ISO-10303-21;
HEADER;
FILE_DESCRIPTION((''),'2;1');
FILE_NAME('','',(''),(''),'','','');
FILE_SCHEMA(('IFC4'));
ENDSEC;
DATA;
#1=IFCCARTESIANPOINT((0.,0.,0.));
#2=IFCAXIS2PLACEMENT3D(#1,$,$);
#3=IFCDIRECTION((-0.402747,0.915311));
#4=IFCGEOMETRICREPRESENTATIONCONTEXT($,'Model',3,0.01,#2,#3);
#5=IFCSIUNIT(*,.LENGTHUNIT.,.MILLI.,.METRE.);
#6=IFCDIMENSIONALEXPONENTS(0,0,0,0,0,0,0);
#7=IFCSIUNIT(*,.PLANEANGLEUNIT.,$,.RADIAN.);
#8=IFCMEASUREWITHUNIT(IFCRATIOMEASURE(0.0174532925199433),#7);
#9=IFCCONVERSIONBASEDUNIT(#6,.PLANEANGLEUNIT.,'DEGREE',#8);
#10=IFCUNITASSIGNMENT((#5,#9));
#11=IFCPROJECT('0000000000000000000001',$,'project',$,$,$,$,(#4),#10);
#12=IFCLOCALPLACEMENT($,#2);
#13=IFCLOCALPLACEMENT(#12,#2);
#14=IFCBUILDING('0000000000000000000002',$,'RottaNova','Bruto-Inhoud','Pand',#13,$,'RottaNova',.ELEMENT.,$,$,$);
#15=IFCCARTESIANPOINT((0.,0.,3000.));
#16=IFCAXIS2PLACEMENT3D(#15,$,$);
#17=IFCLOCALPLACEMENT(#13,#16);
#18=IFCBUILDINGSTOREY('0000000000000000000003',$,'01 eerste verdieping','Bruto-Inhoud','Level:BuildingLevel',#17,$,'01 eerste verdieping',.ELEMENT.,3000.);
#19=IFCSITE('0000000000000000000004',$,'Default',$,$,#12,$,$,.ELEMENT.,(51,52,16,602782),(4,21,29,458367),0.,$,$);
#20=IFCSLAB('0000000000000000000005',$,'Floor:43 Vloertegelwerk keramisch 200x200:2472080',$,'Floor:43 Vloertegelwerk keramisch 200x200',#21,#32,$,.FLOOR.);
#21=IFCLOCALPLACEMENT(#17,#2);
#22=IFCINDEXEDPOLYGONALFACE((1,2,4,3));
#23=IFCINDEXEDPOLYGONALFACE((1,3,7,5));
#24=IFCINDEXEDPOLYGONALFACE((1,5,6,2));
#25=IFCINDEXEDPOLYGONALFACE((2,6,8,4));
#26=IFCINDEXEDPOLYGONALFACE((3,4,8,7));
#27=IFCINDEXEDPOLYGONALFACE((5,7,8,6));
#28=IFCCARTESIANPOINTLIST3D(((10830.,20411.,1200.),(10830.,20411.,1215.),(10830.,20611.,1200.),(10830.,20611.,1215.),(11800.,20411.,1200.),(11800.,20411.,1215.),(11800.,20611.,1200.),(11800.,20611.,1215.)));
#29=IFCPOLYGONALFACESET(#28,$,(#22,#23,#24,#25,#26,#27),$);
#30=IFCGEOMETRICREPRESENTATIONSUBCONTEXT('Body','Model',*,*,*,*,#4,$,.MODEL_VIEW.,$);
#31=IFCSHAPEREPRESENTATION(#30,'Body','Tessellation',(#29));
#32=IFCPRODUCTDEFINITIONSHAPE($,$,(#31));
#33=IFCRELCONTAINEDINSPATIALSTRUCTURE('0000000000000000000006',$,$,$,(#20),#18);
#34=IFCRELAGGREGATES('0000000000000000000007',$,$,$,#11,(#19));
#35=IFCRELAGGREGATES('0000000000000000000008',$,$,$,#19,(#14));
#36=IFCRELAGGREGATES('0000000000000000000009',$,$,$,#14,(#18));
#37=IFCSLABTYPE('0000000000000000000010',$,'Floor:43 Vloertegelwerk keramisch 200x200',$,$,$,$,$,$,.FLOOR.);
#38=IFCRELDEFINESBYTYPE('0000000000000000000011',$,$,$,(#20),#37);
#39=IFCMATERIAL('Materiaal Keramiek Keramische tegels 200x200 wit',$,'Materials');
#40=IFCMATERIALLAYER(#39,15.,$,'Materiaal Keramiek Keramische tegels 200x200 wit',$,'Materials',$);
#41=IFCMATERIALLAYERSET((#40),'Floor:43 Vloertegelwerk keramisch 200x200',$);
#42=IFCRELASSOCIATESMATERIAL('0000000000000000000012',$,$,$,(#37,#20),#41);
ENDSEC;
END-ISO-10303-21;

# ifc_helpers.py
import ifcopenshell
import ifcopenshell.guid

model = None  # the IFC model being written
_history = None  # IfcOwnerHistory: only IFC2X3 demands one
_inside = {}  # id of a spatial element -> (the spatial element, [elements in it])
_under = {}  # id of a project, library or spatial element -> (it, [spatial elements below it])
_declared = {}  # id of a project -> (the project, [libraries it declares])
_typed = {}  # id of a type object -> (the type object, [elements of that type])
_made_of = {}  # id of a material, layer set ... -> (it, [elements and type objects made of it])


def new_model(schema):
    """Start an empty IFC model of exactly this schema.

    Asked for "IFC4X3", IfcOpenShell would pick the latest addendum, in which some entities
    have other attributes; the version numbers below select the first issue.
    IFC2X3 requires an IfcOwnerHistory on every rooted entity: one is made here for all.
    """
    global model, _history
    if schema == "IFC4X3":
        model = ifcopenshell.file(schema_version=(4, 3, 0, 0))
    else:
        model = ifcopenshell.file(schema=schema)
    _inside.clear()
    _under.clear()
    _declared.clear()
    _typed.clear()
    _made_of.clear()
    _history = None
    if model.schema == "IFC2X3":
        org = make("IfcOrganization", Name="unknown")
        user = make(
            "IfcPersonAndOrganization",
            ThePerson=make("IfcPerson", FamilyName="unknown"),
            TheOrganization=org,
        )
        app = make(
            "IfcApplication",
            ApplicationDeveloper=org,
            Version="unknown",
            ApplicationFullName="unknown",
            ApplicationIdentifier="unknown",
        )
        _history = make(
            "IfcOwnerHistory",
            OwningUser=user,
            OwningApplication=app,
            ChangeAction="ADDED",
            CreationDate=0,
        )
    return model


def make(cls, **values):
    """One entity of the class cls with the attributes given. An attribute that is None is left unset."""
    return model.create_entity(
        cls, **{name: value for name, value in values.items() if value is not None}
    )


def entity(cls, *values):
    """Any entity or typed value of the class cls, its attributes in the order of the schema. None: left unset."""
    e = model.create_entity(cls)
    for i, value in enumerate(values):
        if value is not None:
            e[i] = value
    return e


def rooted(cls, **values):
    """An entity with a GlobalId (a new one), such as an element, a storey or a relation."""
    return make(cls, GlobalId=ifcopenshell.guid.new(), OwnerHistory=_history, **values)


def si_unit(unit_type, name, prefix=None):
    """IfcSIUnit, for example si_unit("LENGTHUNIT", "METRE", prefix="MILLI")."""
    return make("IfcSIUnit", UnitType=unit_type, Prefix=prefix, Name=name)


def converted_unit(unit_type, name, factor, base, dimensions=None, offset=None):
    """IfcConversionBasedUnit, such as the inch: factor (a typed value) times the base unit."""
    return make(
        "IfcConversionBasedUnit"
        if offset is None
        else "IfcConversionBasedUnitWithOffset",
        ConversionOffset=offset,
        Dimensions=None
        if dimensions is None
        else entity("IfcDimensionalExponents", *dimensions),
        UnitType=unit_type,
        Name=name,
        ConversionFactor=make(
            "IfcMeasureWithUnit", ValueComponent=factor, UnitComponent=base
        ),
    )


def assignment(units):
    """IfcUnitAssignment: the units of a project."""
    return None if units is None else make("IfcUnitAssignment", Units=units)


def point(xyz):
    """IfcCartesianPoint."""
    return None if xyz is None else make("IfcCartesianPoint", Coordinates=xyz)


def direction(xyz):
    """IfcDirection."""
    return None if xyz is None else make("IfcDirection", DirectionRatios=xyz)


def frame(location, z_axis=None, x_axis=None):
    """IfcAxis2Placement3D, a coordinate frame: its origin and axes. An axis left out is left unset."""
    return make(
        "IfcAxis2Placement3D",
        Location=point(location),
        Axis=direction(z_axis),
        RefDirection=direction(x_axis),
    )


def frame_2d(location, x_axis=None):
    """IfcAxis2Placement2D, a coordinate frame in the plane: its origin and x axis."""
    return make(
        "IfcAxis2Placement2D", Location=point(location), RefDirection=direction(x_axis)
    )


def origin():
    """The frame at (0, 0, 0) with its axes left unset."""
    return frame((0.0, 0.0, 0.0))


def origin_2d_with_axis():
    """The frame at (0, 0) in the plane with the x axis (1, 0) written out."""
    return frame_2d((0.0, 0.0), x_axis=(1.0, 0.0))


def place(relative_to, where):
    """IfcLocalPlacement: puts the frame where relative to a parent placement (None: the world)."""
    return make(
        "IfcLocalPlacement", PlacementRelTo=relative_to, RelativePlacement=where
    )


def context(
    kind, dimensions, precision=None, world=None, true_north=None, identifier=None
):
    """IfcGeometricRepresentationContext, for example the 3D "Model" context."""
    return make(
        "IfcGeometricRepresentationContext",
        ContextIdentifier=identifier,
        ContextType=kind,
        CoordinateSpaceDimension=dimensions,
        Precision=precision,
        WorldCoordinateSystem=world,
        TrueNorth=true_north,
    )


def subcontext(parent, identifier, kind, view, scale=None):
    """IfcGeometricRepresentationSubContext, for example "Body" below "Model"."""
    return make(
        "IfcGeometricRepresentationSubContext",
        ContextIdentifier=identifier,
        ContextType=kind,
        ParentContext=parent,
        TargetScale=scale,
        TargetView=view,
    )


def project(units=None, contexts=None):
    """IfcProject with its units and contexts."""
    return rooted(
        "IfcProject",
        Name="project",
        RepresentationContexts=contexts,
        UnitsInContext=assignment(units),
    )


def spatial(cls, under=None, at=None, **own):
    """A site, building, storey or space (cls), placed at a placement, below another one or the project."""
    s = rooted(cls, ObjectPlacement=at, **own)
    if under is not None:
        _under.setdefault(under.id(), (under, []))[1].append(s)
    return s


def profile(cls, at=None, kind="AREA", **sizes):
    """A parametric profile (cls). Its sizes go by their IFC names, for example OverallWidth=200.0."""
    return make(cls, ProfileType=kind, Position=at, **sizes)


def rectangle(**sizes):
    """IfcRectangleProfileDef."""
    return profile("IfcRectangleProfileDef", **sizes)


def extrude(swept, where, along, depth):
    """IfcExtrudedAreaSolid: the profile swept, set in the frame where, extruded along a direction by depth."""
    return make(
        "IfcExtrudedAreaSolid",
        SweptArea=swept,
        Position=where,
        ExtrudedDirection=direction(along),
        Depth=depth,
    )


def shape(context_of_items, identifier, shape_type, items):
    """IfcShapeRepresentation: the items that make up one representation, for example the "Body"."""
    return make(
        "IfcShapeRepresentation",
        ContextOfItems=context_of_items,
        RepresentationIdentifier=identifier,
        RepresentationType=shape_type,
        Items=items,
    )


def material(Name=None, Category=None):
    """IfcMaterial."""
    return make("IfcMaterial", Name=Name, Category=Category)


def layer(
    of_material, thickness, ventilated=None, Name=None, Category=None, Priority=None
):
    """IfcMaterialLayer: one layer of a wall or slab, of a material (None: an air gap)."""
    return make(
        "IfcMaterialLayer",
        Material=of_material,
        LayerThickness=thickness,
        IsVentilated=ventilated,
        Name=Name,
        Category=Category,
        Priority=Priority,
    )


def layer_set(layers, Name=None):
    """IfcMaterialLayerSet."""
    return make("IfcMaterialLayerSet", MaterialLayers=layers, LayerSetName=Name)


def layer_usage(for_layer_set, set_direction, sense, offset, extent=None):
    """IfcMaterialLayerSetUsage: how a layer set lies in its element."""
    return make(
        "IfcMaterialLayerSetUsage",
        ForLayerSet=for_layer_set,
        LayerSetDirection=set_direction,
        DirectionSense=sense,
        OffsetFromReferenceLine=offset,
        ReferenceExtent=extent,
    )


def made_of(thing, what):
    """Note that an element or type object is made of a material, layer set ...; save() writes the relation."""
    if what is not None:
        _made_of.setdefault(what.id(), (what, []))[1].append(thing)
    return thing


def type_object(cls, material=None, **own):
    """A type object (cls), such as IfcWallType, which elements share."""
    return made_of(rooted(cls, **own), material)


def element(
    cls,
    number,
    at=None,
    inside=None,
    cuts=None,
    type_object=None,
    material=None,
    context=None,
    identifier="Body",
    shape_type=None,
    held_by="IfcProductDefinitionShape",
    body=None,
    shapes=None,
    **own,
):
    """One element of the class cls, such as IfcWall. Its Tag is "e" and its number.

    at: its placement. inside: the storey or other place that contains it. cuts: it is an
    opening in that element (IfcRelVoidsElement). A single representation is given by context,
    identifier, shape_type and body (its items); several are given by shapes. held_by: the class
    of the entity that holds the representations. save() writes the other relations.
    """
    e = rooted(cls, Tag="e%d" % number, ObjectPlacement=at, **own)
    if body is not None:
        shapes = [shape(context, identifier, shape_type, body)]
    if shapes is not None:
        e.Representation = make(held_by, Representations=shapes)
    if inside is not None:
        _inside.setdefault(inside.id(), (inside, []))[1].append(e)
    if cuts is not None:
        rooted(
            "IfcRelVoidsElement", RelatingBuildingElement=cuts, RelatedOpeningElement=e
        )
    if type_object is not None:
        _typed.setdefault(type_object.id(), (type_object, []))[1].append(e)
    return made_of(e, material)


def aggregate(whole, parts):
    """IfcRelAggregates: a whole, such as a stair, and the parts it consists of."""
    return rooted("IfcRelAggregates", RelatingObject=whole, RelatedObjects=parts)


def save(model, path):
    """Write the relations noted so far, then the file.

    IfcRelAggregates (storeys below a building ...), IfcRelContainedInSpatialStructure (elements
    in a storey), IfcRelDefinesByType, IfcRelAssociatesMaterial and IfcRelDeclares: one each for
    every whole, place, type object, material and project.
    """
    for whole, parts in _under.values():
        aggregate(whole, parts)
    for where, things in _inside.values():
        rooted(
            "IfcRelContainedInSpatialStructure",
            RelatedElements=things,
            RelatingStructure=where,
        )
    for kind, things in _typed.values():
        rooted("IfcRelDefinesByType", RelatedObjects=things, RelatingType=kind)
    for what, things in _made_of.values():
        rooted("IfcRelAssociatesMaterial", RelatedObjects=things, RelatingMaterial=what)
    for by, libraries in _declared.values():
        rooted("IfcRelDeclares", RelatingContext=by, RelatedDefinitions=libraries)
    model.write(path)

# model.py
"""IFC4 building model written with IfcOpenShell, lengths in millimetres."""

from ifc_helpers import new_model, entity, si_unit, converted_unit, direction, frame, origin, origin_2d_with_axis, place, context, subcontext, project, spatial, rectangle, extrude, material, layer, layer_set, layer_usage, type_object, element, save


model = new_model("IFC4")

# Units and contexts
model_context = context("Model", 3, precision=0.01, world=origin(), true_north=direction((-0.402747, 0.915311)))
body_context = subcontext(model_context, "Body", "Model", "MODEL_VIEW")
ifc_project = project(units=[si_unit("LENGTHUNIT", "METRE", prefix="MILLI"), converted_unit("PLANEANGLEUNIT", "DEGREE", entity("IfcRatioMeasure", 0.0174532925199433), si_unit("PLANEANGLEUNIT", "RADIAN"), dimensions=[0, 0, 0, 0, 0, 0, 0])], contexts=[model_context])

# Site, building, storey
site_placement = place(None, origin())
site = spatial("IfcSite", under=ifc_project, at=site_placement, Name="Default", CompositionType="ELEMENT", RefLatitude=(51, 52, 16, 602782), RefLongitude=(4, 21, 29, 458367), RefElevation=0.0)
building_placement = place(site_placement, origin())
building = spatial("IfcBuilding", under=site, at=building_placement, Name="RottaNova", Description="Bruto-Inhoud", ObjectType="Pand", LongName="RottaNova", CompositionType="ELEMENT")
storey_placement = place(building_placement, frame((0.0, 0.0, 3000.0)))
storey = spatial("IfcBuildingStorey", under=building, at=storey_placement, Name="01 eerste verdieping", Description="Bruto-Inhoud", ObjectType="Level:BuildingLevel", LongName="01 eerste verdieping", CompositionType="ELEMENT", Elevation=3000.0)

# Slab
ifc_material_1 = material(Name="Materiaal Keramiek Keramische tegels 200x200 wit", Category="Materials")
ifc_layer_1 = layer(ifc_material_1, 15.0, Name="Materiaal Keramiek Keramische tegels 200x200 wit", Category="Materials")
ifc_layer_set_1 = layer_set([ifc_layer_1], Name="Floor:43 Vloertegelwerk keramisch 200x200")
ifc_layer_usage_1 = layer_usage(ifc_layer_set_1, "AXIS3", "POSITIVE", 0.0)
slab_type_1 = type_object("IfcSlabType", Name="Floor:43 Vloertegelwerk keramisch 200x200", PredefinedType="FLOOR", material=ifc_layer_set_1)
slab_1_placement = place(storey_placement, origin())
element("IfcSlab", 1, at=slab_1_placement, inside=storey, type_object=slab_type_1, material=ifc_layer_usage_1, Name="Floor:43 Vloertegelwerk keramisch 200x200:2472080", ObjectType="Floor:43 Vloertegelwerk keramisch 200x200", PredefinedType="FLOOR", context=body_context, shape_type="SweptSolid", body=[
    extrude(rectangle(XDim=200.0, YDim=970.0, at=origin_2d_with_axis()), frame((11315.0, 20511.0, 1215.0), z_axis=(0.0, 0.0, -1.0), x_axis=(0.0, 1.0, 0.0)), (0.0, 0.0, 1.0), 15.0),
])

save(model, "model.ifc")
